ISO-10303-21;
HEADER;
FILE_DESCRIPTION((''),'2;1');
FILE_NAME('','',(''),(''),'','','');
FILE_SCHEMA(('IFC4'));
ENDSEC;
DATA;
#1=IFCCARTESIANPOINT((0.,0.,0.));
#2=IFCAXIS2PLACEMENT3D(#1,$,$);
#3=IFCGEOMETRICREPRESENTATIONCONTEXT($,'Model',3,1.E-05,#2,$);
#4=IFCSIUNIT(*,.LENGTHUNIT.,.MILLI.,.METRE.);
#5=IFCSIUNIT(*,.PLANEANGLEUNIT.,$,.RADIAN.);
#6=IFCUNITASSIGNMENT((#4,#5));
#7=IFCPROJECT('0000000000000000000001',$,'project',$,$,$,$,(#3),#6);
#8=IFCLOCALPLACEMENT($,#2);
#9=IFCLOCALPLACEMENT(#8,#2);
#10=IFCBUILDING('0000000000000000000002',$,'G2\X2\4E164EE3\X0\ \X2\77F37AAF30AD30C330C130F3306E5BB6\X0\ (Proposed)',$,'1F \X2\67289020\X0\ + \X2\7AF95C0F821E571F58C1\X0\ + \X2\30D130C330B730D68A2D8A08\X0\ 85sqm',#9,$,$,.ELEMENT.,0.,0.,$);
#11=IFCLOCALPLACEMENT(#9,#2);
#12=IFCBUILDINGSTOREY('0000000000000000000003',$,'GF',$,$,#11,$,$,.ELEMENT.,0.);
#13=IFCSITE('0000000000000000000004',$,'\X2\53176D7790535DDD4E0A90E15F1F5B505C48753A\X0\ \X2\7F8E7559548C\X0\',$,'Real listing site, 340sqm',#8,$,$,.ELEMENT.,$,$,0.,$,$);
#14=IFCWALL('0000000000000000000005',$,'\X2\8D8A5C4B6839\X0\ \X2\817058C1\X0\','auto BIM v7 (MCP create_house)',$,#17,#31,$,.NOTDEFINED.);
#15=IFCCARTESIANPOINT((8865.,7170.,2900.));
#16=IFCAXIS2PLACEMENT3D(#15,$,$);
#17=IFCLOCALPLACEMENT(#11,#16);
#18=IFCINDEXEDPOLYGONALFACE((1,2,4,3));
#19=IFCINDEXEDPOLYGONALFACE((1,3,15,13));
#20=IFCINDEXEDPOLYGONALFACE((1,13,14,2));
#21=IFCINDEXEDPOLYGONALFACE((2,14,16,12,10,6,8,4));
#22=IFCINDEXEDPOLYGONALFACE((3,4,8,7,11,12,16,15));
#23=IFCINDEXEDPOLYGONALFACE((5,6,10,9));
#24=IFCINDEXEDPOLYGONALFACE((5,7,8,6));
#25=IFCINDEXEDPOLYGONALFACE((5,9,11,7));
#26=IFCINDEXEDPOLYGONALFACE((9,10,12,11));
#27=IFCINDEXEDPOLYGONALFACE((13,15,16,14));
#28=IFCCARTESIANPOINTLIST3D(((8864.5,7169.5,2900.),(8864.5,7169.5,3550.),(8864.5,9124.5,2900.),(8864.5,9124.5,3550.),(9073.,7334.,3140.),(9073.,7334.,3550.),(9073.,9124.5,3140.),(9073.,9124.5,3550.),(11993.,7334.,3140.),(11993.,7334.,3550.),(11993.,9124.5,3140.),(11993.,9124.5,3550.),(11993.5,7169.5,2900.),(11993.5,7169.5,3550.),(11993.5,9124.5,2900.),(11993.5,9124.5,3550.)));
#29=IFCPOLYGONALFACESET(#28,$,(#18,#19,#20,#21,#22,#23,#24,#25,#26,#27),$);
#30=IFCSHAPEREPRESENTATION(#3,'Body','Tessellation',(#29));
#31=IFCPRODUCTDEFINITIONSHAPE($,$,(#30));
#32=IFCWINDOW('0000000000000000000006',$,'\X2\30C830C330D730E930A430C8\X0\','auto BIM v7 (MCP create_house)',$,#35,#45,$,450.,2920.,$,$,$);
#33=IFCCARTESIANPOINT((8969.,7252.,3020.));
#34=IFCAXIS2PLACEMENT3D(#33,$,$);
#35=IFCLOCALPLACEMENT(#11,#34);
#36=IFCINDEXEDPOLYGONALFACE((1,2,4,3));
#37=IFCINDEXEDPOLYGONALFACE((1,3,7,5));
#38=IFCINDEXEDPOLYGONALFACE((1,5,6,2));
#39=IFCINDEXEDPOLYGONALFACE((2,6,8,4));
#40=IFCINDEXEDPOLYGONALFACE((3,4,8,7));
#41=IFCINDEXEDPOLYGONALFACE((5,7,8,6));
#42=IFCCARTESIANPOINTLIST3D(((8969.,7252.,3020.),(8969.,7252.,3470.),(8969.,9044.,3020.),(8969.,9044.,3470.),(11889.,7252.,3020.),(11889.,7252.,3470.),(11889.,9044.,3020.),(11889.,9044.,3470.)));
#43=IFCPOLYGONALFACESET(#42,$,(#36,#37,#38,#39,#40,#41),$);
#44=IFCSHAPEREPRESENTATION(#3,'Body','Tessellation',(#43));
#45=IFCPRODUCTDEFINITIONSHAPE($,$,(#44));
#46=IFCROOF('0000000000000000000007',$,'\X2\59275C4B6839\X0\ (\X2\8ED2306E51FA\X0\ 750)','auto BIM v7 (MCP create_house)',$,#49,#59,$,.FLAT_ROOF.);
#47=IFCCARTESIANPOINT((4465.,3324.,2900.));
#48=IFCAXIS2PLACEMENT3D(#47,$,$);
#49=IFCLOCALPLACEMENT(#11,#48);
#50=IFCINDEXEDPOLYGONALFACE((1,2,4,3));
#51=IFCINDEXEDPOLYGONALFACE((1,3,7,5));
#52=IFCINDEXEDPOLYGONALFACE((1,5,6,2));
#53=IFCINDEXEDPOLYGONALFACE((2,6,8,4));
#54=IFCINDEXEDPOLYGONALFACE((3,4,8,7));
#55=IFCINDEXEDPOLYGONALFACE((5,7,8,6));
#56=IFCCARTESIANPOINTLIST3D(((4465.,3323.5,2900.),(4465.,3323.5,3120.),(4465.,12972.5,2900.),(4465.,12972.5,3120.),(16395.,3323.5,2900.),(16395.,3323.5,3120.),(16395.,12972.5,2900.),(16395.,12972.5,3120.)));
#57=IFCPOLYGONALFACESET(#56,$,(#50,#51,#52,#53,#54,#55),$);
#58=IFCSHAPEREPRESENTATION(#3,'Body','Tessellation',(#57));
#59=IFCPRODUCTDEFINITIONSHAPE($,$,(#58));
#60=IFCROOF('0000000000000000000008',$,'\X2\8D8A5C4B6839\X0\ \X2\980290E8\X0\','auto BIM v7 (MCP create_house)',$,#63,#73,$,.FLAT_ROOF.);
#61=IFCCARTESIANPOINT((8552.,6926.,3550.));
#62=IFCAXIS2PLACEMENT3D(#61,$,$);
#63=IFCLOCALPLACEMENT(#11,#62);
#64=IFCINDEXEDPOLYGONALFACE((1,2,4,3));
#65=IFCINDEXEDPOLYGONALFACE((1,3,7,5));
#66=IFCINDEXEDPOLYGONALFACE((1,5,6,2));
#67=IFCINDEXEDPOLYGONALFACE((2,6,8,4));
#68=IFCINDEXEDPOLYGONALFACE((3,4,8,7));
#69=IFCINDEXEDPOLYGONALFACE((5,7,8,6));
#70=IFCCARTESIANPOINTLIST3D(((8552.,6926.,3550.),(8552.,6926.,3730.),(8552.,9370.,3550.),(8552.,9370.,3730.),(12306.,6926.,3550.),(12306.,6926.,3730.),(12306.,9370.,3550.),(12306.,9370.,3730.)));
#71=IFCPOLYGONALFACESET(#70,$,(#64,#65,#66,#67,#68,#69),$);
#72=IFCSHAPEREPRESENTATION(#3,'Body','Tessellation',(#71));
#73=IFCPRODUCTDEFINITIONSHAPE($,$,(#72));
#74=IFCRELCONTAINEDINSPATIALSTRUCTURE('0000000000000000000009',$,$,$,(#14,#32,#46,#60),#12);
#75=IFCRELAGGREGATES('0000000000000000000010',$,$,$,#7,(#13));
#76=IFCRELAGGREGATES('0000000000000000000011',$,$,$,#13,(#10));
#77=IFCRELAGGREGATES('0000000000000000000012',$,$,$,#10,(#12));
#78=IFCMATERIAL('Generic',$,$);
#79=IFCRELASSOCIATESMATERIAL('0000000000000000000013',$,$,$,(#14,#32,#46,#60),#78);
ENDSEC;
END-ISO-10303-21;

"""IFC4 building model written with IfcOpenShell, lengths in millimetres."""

from ifc_helpers import new_model, si_unit, frame, frame_2d, origin, place, context, project, spatial, rectangle, extrude, material, element, fill, save


model = new_model("IFC4")

# Units and contexts
model_context = context("Model", 3, precision=1e-05, world=origin())
ifc_project = project(units=[si_unit("LENGTHUNIT", "METRE", prefix="MILLI"), si_unit("PLANEANGLEUNIT", "RADIAN")], contexts=[model_context])

# Site, building, storey
site_placement = place(None, origin())
site = spatial("IfcSite", under=ifc_project, at=site_placement, Name="北海道川上郡弟子屈町 美留和", ObjectType="Real listing site, 340sqm", CompositionType="ELEMENT", RefElevation=0.0)
building_placement = place(site_placement, origin())
building = spatial("IfcBuilding", under=site, at=building_placement, Name="G2世代 石窯キッチンの家 (Proposed)", ObjectType="1F 木造 + 竹小舞土壁 + パッシブ設計 85sqm", CompositionType="ELEMENT", ElevationOfRefHeight=0.0, ElevationOfTerrain=0.0)
storey_placement = place(building_placement, origin())
storey = spatial("IfcBuildingStorey", under=building, at=storey_placement, Name="GF", CompositionType="ELEMENT", Elevation=0.0)

# Shared definitions
ifc_material = material(Name="Generic")

# Wall, opening, window
wall_1_placement = place(storey_placement, frame((8865.0, 7170.0, 2900.0)))
wall_1 = element("IfcWall", 1, at=wall_1_placement, inside=storey, material=ifc_material, Name="越屋根 腰壁", Description="auto BIM v7 (MCP create_house)", PredefinedType="NOTDEFINED", context=model_context, shape_type="SweptSolid", body=[
    extrude(rectangle(XDim=3129.0, YDim=1955.0, at=frame_2d((1564.0, 977.0))), frame((8865.0, 7170.0, 2900.0)), (0.0, 0.0, 1.0), 650.0),
])
opening_1_placement = place(storey_placement, frame((8969.0, 7252.0, 3020.0)))
opening_1 = element("IfcOpeningElement", 2, at=opening_1_placement, cuts=wall_1, PredefinedType="NOTDEFINED", context=model_context, shape_type="SweptSolid", body=[
    extrude(rectangle(XDim=2920.0, YDim=1792.0, at=frame_2d((1460.0, 896.0))), frame((8969.0, 7252.0, 3020.0)), (0.0, 0.0, 1.0), 450.0),
])
window_1_placement = place(storey_placement, frame((8969.0, 7252.0, 3020.0)))
window_1 = element("IfcWindow", 3, at=window_1_placement, inside=storey, material=ifc_material, Name="トップライト", Description="auto BIM v7 (MCP create_house)", OverallHeight=450.0, OverallWidth=2920.0, context=model_context, shape_type="SweptSolid", body=[
    extrude(rectangle(XDim=2920.0, YDim=1792.0, at=frame_2d((1460.0, 896.0))), frame((8969.0, 7252.0, 3020.0)), (0.0, 0.0, 1.0), 450.0),
])
fill(opening_1, window_1)

# Roofs
roof_1_placement = place(storey_placement, frame((4465.0, 3324.0, 2900.0)))
element("IfcRoof", 4, at=roof_1_placement, inside=storey, material=ifc_material, Name="大屋根 (軒の出 750)", Description="auto BIM v7 (MCP create_house)", PredefinedType="FLAT_ROOF", context=model_context, shape_type="SweptSolid", body=[
    extrude(rectangle(XDim=11930.0, YDim=9649.0, at=frame_2d((5965.0, 4824.0))), frame((4465.0, 3324.0, 2900.0)), (0.0, 0.0, 1.0), 220.0),
])
roof_2_placement = place(storey_placement, frame((8552.0, 6926.0, 3550.0)))
element("IfcRoof", 5, at=roof_2_placement, inside=storey, material=ifc_material, Name="越屋根 頂部", Description="auto BIM v7 (MCP create_house)", PredefinedType="FLAT_ROOF", context=model_context, shape_type="SweptSolid", body=[
    extrude(rectangle(XDim=3754.0, YDim=2444.0, at=frame_2d((1877.0, 1222.0))), frame((8552.0, 6926.0, 3550.0)), (0.0, 0.0, 1.0), 180.0),
])

save(model, "model.ifc")
